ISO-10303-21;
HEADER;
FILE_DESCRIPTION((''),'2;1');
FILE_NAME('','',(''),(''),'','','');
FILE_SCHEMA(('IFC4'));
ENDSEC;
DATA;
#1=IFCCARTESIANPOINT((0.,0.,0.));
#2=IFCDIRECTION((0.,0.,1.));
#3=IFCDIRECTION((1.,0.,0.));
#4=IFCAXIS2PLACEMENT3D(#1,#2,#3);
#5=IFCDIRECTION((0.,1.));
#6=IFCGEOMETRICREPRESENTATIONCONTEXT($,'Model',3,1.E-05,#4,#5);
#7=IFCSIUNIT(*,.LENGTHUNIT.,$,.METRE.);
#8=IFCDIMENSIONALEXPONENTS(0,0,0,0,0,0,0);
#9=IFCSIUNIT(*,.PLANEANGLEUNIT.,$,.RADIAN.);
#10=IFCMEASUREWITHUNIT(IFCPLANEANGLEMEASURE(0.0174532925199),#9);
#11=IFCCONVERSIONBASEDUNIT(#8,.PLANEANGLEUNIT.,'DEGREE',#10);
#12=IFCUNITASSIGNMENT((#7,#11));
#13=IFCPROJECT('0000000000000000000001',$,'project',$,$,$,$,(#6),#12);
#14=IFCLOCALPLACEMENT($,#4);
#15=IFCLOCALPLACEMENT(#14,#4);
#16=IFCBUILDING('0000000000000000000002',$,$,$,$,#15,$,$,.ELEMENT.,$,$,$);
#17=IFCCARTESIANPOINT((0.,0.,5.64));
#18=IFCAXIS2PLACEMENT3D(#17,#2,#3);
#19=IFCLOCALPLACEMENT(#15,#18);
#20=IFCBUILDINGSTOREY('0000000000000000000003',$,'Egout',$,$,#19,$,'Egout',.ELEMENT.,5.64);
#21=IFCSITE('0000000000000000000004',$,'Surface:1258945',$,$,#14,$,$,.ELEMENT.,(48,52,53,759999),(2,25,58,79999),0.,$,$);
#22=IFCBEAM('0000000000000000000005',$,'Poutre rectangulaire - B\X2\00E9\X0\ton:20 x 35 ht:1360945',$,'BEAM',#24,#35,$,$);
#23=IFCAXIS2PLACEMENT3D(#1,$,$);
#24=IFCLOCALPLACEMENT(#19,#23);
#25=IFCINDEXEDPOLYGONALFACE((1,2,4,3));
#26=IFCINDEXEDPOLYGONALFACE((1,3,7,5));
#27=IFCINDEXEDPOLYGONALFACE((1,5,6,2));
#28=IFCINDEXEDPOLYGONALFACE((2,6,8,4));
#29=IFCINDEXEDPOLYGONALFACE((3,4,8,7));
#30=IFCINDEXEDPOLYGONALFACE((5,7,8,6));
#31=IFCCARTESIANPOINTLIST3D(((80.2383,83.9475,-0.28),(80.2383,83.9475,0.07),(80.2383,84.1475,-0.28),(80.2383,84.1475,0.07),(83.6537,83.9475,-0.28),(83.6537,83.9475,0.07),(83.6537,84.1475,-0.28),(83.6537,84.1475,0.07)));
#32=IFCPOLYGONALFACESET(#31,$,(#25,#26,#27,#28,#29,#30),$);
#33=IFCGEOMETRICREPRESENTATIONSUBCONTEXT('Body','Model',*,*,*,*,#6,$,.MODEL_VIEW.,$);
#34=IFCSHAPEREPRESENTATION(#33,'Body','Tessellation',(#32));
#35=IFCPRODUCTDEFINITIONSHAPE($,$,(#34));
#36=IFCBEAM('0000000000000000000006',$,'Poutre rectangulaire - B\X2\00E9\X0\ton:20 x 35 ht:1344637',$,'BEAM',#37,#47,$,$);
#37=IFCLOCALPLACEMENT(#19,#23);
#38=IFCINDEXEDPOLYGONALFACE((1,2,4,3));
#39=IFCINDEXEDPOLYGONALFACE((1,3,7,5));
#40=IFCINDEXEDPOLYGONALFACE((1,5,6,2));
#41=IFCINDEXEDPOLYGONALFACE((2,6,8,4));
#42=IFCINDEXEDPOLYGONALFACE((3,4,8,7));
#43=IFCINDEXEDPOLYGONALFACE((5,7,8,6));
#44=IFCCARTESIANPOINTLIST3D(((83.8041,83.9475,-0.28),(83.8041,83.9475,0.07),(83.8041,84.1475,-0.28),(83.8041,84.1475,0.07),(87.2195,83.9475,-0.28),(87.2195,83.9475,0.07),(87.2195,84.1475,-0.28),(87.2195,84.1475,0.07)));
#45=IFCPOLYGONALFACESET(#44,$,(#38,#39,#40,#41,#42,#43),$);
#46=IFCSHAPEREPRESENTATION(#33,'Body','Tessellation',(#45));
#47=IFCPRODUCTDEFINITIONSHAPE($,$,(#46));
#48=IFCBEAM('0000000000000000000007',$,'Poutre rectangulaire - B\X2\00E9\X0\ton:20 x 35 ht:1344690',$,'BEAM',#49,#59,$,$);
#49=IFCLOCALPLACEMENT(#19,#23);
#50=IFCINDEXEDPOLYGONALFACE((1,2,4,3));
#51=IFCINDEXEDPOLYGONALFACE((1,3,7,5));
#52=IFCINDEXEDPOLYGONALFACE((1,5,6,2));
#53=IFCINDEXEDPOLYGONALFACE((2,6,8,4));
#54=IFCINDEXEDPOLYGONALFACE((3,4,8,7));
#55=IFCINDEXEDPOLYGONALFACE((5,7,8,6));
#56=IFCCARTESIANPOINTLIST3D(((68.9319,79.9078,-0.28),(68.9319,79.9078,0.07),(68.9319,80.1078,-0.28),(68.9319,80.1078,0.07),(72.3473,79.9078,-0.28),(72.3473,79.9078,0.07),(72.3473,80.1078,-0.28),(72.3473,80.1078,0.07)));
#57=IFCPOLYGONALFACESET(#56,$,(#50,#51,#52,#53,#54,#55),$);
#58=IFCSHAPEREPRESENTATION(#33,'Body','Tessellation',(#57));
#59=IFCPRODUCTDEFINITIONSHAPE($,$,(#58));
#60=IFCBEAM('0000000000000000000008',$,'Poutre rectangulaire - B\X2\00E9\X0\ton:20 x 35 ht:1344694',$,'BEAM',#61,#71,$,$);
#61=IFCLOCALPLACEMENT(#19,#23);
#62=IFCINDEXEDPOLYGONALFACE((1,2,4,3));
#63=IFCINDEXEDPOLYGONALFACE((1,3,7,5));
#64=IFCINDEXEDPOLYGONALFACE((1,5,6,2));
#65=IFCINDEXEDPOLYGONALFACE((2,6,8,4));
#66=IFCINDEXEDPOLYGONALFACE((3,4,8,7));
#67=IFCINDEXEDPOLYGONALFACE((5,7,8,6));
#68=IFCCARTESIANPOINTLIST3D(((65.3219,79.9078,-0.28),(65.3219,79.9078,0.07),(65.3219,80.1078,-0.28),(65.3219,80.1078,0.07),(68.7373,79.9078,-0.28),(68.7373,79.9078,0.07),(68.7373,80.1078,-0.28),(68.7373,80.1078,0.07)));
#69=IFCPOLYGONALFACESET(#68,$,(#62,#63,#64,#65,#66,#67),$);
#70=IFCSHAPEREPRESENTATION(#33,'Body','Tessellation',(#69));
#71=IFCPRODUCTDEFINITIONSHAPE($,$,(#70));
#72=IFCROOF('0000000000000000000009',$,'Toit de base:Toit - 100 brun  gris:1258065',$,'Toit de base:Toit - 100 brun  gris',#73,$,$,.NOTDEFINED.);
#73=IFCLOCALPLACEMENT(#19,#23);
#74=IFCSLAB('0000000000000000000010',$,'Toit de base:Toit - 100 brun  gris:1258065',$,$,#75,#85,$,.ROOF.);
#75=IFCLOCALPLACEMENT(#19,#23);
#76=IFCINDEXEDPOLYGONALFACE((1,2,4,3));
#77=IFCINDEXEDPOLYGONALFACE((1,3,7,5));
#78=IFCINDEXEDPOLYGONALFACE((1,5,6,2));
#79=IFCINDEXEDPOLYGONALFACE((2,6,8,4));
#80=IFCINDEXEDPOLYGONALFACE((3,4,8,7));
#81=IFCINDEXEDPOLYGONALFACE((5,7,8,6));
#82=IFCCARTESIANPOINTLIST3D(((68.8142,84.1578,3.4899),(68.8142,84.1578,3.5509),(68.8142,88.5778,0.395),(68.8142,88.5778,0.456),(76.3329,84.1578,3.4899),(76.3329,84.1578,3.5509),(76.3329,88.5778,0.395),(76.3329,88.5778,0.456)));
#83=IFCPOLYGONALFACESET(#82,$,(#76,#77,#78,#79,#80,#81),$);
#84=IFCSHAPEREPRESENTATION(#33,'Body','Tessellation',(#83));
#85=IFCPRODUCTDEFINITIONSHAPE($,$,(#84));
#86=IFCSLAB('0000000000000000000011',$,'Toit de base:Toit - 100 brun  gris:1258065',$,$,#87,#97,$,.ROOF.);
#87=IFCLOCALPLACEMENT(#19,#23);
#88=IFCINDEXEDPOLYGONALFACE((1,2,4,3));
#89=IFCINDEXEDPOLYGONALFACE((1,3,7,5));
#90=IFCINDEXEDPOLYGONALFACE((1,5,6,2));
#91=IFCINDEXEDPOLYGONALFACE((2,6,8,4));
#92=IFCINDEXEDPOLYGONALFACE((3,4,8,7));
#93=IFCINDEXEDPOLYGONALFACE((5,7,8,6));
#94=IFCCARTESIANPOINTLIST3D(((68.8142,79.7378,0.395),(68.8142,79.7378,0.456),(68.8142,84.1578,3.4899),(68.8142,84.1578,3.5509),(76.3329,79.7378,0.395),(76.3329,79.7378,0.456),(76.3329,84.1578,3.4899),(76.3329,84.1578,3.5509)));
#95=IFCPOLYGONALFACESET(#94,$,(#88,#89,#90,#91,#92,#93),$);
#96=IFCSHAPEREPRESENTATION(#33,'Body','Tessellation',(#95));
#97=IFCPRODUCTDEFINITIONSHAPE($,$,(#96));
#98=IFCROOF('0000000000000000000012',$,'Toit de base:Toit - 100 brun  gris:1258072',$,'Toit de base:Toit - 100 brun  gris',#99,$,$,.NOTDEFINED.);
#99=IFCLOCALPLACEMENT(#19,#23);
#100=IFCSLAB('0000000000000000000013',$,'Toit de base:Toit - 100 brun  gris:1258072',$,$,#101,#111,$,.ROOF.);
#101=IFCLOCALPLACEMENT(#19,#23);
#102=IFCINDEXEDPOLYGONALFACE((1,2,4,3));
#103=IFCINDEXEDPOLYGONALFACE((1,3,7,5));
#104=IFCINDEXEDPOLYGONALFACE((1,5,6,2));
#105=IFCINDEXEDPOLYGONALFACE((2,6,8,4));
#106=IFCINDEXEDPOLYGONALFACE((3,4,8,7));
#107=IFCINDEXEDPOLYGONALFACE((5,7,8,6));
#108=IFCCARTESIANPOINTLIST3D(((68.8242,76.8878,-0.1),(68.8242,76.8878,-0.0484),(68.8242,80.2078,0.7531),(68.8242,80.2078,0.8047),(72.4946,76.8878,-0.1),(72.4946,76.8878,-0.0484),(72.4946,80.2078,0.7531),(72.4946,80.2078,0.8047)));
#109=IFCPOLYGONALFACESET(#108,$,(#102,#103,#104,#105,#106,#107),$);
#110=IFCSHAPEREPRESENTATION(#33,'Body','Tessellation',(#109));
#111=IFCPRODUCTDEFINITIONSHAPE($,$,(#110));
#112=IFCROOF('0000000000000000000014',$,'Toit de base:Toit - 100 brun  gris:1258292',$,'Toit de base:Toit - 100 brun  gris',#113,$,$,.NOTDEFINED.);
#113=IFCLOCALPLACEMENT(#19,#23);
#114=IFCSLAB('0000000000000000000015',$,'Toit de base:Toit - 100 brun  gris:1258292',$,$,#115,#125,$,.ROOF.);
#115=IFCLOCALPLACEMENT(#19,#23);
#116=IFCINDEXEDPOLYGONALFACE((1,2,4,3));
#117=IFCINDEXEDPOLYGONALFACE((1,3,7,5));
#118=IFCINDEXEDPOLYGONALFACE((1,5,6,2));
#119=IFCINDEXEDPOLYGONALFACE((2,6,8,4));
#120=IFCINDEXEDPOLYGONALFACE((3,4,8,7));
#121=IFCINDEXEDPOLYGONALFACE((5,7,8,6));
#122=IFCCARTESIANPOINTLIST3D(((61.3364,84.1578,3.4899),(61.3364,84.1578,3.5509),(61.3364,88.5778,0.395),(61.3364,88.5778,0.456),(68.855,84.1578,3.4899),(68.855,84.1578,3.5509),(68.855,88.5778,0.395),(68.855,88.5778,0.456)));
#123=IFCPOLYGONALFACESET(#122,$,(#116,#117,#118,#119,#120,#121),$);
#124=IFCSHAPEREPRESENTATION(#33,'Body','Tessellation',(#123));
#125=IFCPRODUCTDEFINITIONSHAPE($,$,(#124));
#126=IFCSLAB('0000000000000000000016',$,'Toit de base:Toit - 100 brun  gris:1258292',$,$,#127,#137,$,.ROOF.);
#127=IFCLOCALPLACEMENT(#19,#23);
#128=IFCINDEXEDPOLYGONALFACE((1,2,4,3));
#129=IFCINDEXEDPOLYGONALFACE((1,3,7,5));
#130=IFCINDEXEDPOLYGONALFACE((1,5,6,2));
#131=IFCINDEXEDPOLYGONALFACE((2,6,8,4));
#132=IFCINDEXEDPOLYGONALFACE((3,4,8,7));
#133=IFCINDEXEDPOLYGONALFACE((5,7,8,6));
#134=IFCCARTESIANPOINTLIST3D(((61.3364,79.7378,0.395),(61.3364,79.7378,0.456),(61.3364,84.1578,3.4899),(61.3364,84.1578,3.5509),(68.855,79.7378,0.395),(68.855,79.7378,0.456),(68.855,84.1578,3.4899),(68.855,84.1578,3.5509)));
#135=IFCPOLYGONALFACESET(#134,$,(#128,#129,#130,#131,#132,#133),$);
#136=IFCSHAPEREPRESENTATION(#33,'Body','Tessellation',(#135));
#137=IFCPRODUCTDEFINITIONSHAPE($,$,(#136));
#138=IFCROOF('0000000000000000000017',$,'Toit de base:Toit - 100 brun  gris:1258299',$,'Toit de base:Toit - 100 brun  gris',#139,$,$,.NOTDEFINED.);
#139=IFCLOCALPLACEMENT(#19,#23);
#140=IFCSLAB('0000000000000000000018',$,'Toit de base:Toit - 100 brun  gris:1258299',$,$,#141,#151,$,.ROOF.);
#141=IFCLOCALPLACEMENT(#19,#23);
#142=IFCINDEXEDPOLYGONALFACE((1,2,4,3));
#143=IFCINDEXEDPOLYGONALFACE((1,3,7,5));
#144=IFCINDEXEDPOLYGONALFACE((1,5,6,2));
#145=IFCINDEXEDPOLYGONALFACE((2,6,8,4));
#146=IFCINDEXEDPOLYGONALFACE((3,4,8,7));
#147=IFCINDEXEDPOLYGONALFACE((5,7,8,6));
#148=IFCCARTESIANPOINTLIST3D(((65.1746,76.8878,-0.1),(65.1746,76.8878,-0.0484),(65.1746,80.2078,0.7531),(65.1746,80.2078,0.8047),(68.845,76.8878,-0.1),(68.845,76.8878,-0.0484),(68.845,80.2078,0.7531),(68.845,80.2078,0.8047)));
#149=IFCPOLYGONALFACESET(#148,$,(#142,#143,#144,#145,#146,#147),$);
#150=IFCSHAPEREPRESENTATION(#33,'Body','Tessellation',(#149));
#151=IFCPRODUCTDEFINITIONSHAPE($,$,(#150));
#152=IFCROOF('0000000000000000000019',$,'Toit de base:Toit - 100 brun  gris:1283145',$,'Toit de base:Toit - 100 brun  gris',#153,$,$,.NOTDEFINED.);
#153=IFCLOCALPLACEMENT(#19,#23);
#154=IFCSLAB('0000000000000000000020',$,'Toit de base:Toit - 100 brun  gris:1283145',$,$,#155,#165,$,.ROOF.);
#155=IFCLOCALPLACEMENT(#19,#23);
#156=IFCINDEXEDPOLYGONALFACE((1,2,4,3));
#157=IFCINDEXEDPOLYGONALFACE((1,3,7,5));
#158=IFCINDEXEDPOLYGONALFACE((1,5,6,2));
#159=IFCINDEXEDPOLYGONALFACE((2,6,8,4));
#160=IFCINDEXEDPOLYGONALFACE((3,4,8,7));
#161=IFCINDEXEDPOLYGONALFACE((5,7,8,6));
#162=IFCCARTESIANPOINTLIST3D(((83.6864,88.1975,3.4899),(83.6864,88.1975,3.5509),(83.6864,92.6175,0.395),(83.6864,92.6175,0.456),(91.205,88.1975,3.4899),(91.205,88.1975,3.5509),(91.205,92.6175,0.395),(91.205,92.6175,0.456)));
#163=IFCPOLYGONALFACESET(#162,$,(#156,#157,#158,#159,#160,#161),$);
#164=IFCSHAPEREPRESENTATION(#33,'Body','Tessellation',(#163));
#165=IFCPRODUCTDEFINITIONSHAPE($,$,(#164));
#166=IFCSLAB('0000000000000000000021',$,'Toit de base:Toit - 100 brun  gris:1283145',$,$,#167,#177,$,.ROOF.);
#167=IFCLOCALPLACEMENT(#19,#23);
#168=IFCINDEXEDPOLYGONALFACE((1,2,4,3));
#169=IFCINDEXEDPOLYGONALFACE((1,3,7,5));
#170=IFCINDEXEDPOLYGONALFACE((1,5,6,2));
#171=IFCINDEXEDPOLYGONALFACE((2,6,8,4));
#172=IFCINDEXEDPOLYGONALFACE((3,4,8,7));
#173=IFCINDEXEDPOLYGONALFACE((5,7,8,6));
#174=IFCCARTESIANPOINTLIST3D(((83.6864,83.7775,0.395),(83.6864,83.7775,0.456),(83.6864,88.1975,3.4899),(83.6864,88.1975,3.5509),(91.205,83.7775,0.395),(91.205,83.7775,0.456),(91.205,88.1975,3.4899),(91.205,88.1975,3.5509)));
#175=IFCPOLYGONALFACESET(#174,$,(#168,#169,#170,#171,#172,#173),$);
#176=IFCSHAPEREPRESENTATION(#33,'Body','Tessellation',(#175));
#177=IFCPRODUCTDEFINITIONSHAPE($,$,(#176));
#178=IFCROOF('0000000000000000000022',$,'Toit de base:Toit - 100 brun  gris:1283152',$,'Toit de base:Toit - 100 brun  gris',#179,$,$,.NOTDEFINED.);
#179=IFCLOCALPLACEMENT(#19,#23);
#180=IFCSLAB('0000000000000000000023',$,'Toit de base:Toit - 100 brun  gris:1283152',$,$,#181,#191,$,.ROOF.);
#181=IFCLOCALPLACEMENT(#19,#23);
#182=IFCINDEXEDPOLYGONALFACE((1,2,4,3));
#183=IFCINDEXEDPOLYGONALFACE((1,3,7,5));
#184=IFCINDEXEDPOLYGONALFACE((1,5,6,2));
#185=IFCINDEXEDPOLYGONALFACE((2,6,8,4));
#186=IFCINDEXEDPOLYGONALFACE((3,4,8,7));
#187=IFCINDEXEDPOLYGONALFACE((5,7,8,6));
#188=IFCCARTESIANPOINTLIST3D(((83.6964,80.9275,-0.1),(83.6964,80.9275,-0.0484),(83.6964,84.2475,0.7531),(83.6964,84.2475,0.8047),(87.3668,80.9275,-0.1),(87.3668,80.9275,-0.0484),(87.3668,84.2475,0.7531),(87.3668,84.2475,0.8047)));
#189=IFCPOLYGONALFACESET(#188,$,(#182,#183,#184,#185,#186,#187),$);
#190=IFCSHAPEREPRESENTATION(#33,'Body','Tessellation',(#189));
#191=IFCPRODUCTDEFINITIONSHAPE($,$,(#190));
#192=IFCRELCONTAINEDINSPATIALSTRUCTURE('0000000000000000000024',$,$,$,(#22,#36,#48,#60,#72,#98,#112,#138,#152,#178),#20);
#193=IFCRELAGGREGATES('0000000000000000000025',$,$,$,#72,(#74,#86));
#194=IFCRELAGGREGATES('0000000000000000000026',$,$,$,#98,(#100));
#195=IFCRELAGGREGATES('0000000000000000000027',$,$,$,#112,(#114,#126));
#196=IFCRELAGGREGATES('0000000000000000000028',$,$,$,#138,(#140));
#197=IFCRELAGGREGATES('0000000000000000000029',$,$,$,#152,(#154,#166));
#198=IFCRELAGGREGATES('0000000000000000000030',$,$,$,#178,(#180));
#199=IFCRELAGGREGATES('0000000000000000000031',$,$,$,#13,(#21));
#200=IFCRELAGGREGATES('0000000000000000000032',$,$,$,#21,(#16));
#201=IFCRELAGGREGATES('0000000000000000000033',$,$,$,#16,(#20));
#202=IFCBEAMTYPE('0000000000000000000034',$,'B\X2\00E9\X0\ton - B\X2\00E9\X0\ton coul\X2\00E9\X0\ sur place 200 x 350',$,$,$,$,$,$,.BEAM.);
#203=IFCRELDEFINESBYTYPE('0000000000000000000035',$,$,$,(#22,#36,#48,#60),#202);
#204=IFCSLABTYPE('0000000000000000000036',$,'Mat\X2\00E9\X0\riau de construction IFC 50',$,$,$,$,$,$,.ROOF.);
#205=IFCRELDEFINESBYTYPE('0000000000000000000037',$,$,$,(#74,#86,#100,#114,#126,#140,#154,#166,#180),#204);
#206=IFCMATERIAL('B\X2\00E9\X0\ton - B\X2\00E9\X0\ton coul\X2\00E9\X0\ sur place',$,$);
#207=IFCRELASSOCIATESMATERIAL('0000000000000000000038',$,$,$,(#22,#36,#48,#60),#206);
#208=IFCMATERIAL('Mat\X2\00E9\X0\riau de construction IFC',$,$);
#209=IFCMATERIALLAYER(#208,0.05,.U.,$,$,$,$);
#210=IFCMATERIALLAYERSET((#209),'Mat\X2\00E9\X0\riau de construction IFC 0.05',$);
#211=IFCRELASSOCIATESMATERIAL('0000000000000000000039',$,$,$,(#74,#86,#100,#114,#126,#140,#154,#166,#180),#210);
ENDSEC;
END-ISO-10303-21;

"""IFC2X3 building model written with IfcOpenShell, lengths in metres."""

from ifc_helpers import new_model, entity, si_unit, converted_unit, direction, frame, frame_2d, origin_with_axes, place, context, subcontext, project, spatial, polyline, rectangle, outline, extrude, material, layer, layer_set, layer_usage, type_object, element, aggregate, save


model = new_model("IFC2X3")

# Units and contexts
model_context = context("Model", 3, precision=1e-05, world=origin_with_axes(), true_north=direction((0.0, 1.0)))
body_context = subcontext(model_context, "Body", "Model", "MODEL_VIEW")
ifc_project = project(units=[si_unit("LENGTHUNIT", "METRE"), converted_unit("PLANEANGLEUNIT", "DEGREE", entity("IfcPlaneAngleMeasure", 0.0174532925199), si_unit("PLANEANGLEUNIT", "RADIAN"), dimensions=[0, 0, 0, 0, 0, 0, 0])], contexts=[model_context])

# Site, building, storey
site_placement = place(None, origin_with_axes())
site = spatial("IfcSite", under=ifc_project, at=site_placement, Name="Surface:1258945", CompositionType="ELEMENT", RefLatitude=(48, 52, 53, 759999), RefLongitude=(2, 25, 58, 79999), RefElevation=0.0)
building_placement = place(site_placement, origin_with_axes())
building = spatial("IfcBuilding", under=site, at=building_placement, CompositionType="ELEMENT")
storey_placement = place(building_placement, frame((0.0, 0.0, 5.64), z_axis=(0.0, 0.0, 1.0), x_axis=(1.0, 0.0, 0.0)))
storey = spatial("IfcBuildingStorey", under=building, at=storey_placement, Name="Egout", LongName="Egout", CompositionType="ELEMENT", Elevation=5.64)

# Beams
ifc_material_1 = material(Name="Béton - Béton coulé sur place")
beam_type = type_object("IfcBeamType", Name="Béton - Béton coulé sur place 200 x 350", PredefinedType="BEAM")
for number, where, z_axis, x_axis, name in (
    (1, (83.6537, 84.0475, 0.07), (0.0, 0.0, 1.0), (0.0, 1.0, 0.0), "Poutre rectangulaire - Béton:20 x 35 ht:1360945"),
    (2, (83.8041, 84.0475, 0.07), (0.0, 0.0, 1.0), (0.0, -1.0, 0.0), "Poutre rectangulaire - Béton:20 x 35 ht:1344637"),
    (3, (68.9319, 80.0078, 0.07), (0.0, 0.0, 1.0), (0.0, -1.0, 0.0), "Poutre rectangulaire - Béton:20 x 35 ht:1344690"),
    (4, (68.7373, 80.0078, 0.07), (0.0, 0.0, 1.0), (0.0, 1.0, 0.0), "Poutre rectangulaire - Béton:20 x 35 ht:1344694"),
):
    element("IfcBeam", number, at=place(storey_placement, frame(where, z_axis=z_axis, x_axis=x_axis)), inside=storey, type_object=beam_type, material=ifc_material_1, Name=name, ObjectType="BEAM", context=body_context, shape_type="SweptSolid", body=[
        extrude(rectangle(XDim=0.35, YDim=0.2, at=frame_2d((-0.175, 0.0), x_axis=(1.0, 0.0))), frame((0.0, 0.0, 0.0), z_axis=(0.0, 1.0, 0.0), x_axis=(0.0, 0.0, 1.0)), (0.0, 0.0, 1.0), 3.4154),
    ])

# Roof, slabs
roof_1_placement = place(storey_placement, frame((0.0, 0.0, -5.64), z_axis=(0.0, 0.0, 1.0), x_axis=(1.0, 0.0, 0.0)))
roof_1 = element("IfcRoof", 5, at=roof_1_placement, inside=storey, Name="Toit de base:Toit - 100 brun  gris:1258065", ObjectType="Toit de base:Toit - 100 brun  gris", ShapeType="NOTDEFINED")
ifc_material_2 = material(Name="Matériau de construction IFC")
ifc_layer = layer(ifc_material_2, 0.05, ventilated="UNKNOWN")
ifc_layer_set = layer_set([ifc_layer], Name="Matériau de construction IFC 0.05")
ifc_layer_usage_1 = layer_usage(ifc_layer_set, "AXIS3", "NEGATIVE", 0.05)
slab_type = type_object("IfcSlabType", Name="Matériau de construction IFC 50", PredefinedType="ROOF")
slab_1_placement = place(roof_1_placement, frame((76.3329, 86.3678, 7.5824), z_axis=(0.0, 0.0, 1.0), x_axis=(-1.0, 0.0, 0.0)))
slab_1 = element("IfcSlab", 6, at=slab_1_placement, type_object=slab_type, material=ifc_layer_usage_1, Name="Toit de base:Toit - 100 brun  gris:1258065", PredefinedType="ROOF", context=body_context, shape_type="SweptSolid", body=[
    extrude(outline(polyline([(7.5186, 2.6979), (0.0, 2.6979), (0.0, -2.6979), (7.5186, -2.6979), (7.5186, 2.6979)])), frame((0.0, 0.0, 0.0), z_axis=(0.0, -0.573576, 0.819152), x_axis=(1.0, 0.0, 0.0)), (0.0, 0.573576, 0.819152), 0.061),
])
ifc_layer_usage_2 = layer_usage(ifc_layer_set, "AXIS3", "NEGATIVE", 0.05)
slab_2_placement = place(roof_1_placement, frame((68.8142, 81.9478, 7.5824), z_axis=(0.0, 0.0, 1.0), x_axis=(1.0, 0.0, 0.0)))
slab_2 = element("IfcSlab", 7, at=slab_2_placement, type_object=slab_type, material=ifc_layer_usage_2, Name="Toit de base:Toit - 100 brun  gris:1258065", PredefinedType="ROOF", context=body_context, shape_type="SweptSolid", body=[
    extrude(outline(polyline([(0.0, 2.6979), (0.0, -2.6979), (7.5186, -2.6979), (7.5186, 2.6979), (0.0, 2.6979)])), frame((0.0, 0.0, 0.0), z_axis=(0.0, -0.573576, 0.819152), x_axis=(1.0, 0.0, 0.0)), (0.0, 0.573576, 0.819152), 0.061),
])
aggregate(roof_1, [slab_1, slab_2])

# Roof, slab
roof_2_placement = place(storey_placement, frame((0.0, 0.0, -5.64), z_axis=(0.0, 0.0, 1.0), x_axis=(1.0, 0.0, 0.0)))
roof_2 = element("IfcRoof", 8, at=roof_2_placement, inside=storey, Name="Toit de base:Toit - 100 brun  gris:1258072", ObjectType="Toit de base:Toit - 100 brun  gris", ShapeType="NOTDEFINED")
ifc_layer_usage_3 = layer_usage(ifc_layer_set, "AXIS3", "NEGATIVE", 0.05)
slab_3_placement = place(roof_2_placement, frame((68.8242, 78.5478, 5.9665), z_axis=(0.0, 0.0, 1.0), x_axis=(1.0, 0.0, 0.0)))
slab_3 = element("IfcSlab", 9, at=slab_3_placement, type_object=slab_type, material=ifc_layer_usage_3, Name="Toit de base:Toit - 100 brun  gris:1258072", PredefinedType="ROOF", context=body_context, shape_type="SweptSolid", body=[
    extrude(outline(polyline([(3.6704, -1.7139), (3.6704, 1.7139), (0.0, 1.7139), (0.0, -1.7139), (3.6704, -1.7139)])), frame((0.0, 0.0, 0.0), z_axis=(0.0, -0.248865, 0.968538), x_axis=(1.0, 0.0, 0.0)), (0.0, 0.248865, 0.968538), 0.0516),
])
aggregate(roof_2, [slab_3])

# Roof, slabs
roof_3_placement = place(storey_placement, frame((0.0, 0.0, -5.64), z_axis=(0.0, 0.0, 1.0), x_axis=(1.0, 0.0, 0.0)))
roof_3 = element("IfcRoof", 10, at=roof_3_placement, inside=storey, Name="Toit de base:Toit - 100 brun  gris:1258292", ObjectType="Toit de base:Toit - 100 brun  gris", ShapeType="NOTDEFINED")
ifc_layer_usage_4 = layer_usage(ifc_layer_set, "AXIS3", "NEGATIVE", 0.05)
slab_4_placement = place(roof_3_placement, frame((68.855, 86.3678, 7.5824), z_axis=(0.0, 0.0, 1.0), x_axis=(-1.0, 0.0, 0.0)))
slab_4 = element("IfcSlab", 11, at=slab_4_placement, type_object=slab_type, material=ifc_layer_usage_4, Name="Toit de base:Toit - 100 brun  gris:1258292", PredefinedType="ROOF", context=body_context, shape_type="SweptSolid", body=[
    extrude(outline(polyline([(0.0, 2.6979), (0.0, -2.6979), (7.5186, -2.6979), (7.5186, 2.6979), (0.0, 2.6979)])), frame((0.0, 0.0, 0.0), z_axis=(0.0, -0.573576, 0.819152), x_axis=(1.0, 0.0, 0.0)), (0.0, 0.573576, 0.819152), 0.061),
])
ifc_layer_usage_5 = layer_usage(ifc_layer_set, "AXIS3", "NEGATIVE", 0.05)
slab_5_placement = place(roof_3_placement, frame((61.3364, 81.9478, 7.5824), z_axis=(0.0, 0.0, 1.0), x_axis=(1.0, 0.0, 0.0)))
slab_5 = element("IfcSlab", 12, at=slab_5_placement, type_object=slab_type, material=ifc_layer_usage_5, Name="Toit de base:Toit - 100 brun  gris:1258292", PredefinedType="ROOF", context=body_context, shape_type="SweptSolid", body=[
    extrude(outline(polyline([(7.5186, 2.6979), (0.0, 2.6979), (0.0, -2.6979), (7.5186, -2.6979), (7.5186, 2.6979)])), frame((0.0, 0.0, 0.0), z_axis=(0.0, -0.573576, 0.819152), x_axis=(1.0, 0.0, 0.0)), (0.0, 0.573576, 0.819152), 0.061),
])
aggregate(roof_3, [slab_4, slab_5])

# Roof, slab
roof_4_placement = place(storey_placement, frame((0.0, 0.0, -5.64), z_axis=(0.0, 0.0, 1.0), x_axis=(1.0, 0.0, 0.0)))
roof_4 = element("IfcRoof", 13, at=roof_4_placement, inside=storey, Name="Toit de base:Toit - 100 brun  gris:1258299", ObjectType="Toit de base:Toit - 100 brun  gris", ShapeType="NOTDEFINED")
ifc_layer_usage_6 = layer_usage(ifc_layer_set, "AXIS3", "NEGATIVE", 0.05)
slab_6_placement = place(roof_4_placement, frame((65.1746, 78.5478, 5.9665), z_axis=(0.0, 0.0, 1.0), x_axis=(1.0, 0.0, 0.0)))
slab_6 = element("IfcSlab", 14, at=slab_6_placement, type_object=slab_type, material=ifc_layer_usage_6, Name="Toit de base:Toit - 100 brun  gris:1258299", PredefinedType="ROOF", context=body_context, shape_type="SweptSolid", body=[
    extrude(outline(polyline([(0.0, 1.7139), (0.0, -1.7139), (3.6704, -1.7139), (3.6704, 1.7139), (0.0, 1.7139)])), frame((0.0, 0.0, 0.0), z_axis=(0.0, -0.248865, 0.968538), x_axis=(1.0, 0.0, 0.0)), (0.0, 0.248865, 0.968538), 0.0516),
])
aggregate(roof_4, [slab_6])

# Roof, slabs
roof_5_placement = place(storey_placement, frame((0.0, 0.0, -5.64), z_axis=(0.0, 0.0, 1.0), x_axis=(1.0, 0.0, 0.0)))
roof_5 = element("IfcRoof", 15, at=roof_5_placement, inside=storey, Name="Toit de base:Toit - 100 brun  gris:1283145", ObjectType="Toit de base:Toit - 100 brun  gris", ShapeType="NOTDEFINED")
ifc_layer_usage_7 = layer_usage(ifc_layer_set, "AXIS3", "NEGATIVE", 0.05)
slab_7_placement = place(roof_5_placement, frame((91.205, 90.4075, 7.5824), z_axis=(0.0, 0.0, 1.0), x_axis=(-1.0, 0.0, 0.0)))
slab_7 = element("IfcSlab", 16, at=slab_7_placement, type_object=slab_type, material=ifc_layer_usage_7, Name="Toit de base:Toit - 100 brun  gris:1283145", PredefinedType="ROOF", context=body_context, shape_type="SweptSolid", body=[
    extrude(outline(polyline([(7.5186, 2.6979), (0.0, 2.6979), (0.0, -2.6979), (7.5186, -2.6979), (7.5186, 2.6979)])), frame((0.0, 0.0, 0.0), z_axis=(0.0, -0.573576, 0.819152), x_axis=(1.0, 0.0, 0.0)), (0.0, 0.573576, 0.819152), 0.061),
])
ifc_layer_usage_8 = layer_usage(ifc_layer_set, "AXIS3", "NEGATIVE", 0.05)
slab_8_placement = place(roof_5_placement, frame((83.6864, 85.9875, 7.5824), z_axis=(0.0, 0.0, 1.0), x_axis=(1.0, 0.0, 0.0)))
slab_8 = element("IfcSlab", 17, at=slab_8_placement, type_object=slab_type, material=ifc_layer_usage_8, Name="Toit de base:Toit - 100 brun  gris:1283145", PredefinedType="ROOF", context=body_context, shape_type="SweptSolid", body=[
    extrude(outline(polyline([(0.0, 2.6979), (0.0, -2.6979), (7.5186, -2.6979), (7.5186, 2.6979), (0.0, 2.6979)])), frame((0.0, 0.0, 0.0), z_axis=(0.0, -0.573576, 0.819152), x_axis=(1.0, 0.0, 0.0)), (0.0, 0.573576, 0.819152), 0.061),
])
aggregate(roof_5, [slab_7, slab_8])

# Roof, slab
roof_6_placement = place(storey_placement, frame((0.0, 0.0, -5.64), z_axis=(0.0, 0.0, 1.0), x_axis=(1.0, 0.0, 0.0)))
roof_6 = element("IfcRoof", 18, at=roof_6_placement, inside=storey, Name="Toit de base:Toit - 100 brun  gris:1283152", ObjectType="Toit de base:Toit - 100 brun  gris", ShapeType="NOTDEFINED")
ifc_layer_usage_9 = layer_usage(ifc_layer_set, "AXIS3", "NEGATIVE", 0.05)
slab_9_placement = place(roof_6_placement, frame((83.6964, 82.5875, 5.9665), z_axis=(0.0, 0.0, 1.0), x_axis=(1.0, 0.0, 0.0)))
slab_9 = element("IfcSlab", 19, at=slab_9_placement, type_object=slab_type, material=ifc_layer_usage_9, Name="Toit de base:Toit - 100 brun  gris:1283152", PredefinedType="ROOF", context=body_context, shape_type="SweptSolid", body=[
    extrude(outline(polyline([(3.6704, -1.7139), (3.6704, 1.7139), (0.0, 1.7139), (0.0, -1.7139), (3.6704, -1.7139)])), frame((0.0, 0.0, 0.0), z_axis=(0.0, -0.248865, 0.968538), x_axis=(1.0, 0.0, 0.0)), (0.0, 0.248865, 0.968538), 0.0516),
])
aggregate(roof_6, [slab_9])

save(model, "model.ifc")
